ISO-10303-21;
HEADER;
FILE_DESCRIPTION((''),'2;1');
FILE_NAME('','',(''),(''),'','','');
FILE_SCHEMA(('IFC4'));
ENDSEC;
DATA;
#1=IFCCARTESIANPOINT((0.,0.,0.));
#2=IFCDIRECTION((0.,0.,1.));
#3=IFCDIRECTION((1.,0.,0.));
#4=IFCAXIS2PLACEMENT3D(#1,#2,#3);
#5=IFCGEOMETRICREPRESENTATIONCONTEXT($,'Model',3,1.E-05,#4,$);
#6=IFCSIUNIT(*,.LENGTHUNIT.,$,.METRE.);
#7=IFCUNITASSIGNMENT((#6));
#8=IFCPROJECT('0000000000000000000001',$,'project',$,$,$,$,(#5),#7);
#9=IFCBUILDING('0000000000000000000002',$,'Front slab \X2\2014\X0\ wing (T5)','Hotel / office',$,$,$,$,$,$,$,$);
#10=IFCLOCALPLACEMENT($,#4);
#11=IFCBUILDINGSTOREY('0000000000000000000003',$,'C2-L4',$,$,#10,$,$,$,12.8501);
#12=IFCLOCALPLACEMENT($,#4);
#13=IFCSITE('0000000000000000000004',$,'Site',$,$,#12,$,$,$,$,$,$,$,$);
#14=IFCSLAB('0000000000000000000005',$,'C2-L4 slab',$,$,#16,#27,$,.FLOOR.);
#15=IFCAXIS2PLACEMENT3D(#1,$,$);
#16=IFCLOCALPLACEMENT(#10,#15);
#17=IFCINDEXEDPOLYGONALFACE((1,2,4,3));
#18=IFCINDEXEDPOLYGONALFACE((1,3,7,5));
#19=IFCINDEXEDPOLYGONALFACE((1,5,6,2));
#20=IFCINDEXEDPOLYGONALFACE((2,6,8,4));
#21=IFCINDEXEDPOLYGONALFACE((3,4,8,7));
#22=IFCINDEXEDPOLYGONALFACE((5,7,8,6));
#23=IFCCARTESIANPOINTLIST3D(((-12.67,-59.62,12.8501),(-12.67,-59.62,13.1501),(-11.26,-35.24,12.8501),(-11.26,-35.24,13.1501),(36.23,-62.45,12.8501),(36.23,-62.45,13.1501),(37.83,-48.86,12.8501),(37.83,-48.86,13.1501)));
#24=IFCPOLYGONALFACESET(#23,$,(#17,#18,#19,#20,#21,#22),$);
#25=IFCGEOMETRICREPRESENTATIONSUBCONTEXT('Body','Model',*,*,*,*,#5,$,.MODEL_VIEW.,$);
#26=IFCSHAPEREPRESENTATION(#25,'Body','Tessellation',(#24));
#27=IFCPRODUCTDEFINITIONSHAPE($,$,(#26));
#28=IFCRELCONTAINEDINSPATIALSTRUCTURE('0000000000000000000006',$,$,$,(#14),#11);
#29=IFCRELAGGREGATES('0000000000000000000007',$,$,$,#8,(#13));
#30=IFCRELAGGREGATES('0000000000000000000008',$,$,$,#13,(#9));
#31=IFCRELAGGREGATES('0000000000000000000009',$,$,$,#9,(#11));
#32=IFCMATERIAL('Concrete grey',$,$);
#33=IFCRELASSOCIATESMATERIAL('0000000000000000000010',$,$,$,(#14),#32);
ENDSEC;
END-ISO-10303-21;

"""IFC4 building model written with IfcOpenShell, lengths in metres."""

from ifc_helpers import new_model, si_unit, frame, origin_with_axes, place, context, subcontext, project, spatial, polyline, outline, extrude, material, element, save


model = new_model("IFC4")

# Units and contexts
model_context = context("Model", 3, precision=1e-05, world=origin_with_axes())
body_context = subcontext(model_context, "Body", "Model", "MODEL_VIEW")
ifc_project = project(units=[si_unit("LENGTHUNIT", "METRE")], contexts=[model_context])

# Site, building, storey
site_placement = place(None, origin_with_axes())
site = spatial("IfcSite", under=ifc_project, at=site_placement, Name="Site")
building = spatial("IfcBuilding", under=site, Name="Front slab — wing (T5)", Description="Hotel / office")
storey_placement = place(None, origin_with_axes())
storey = spatial("IfcBuildingStorey", under=building, at=storey_placement, Name="C2-L4", Elevation=12.8501)

# Slab
ifc_material_1 = material(Name="Concrete grey")
slab_placement = place(storey_placement, origin_with_axes())
element("IfcSlab", 1, at=slab_placement, inside=storey, material=ifc_material_1, Name="C2-L4 slab", PredefinedType="FLOOR", context=body_context, shape_type="SweptSolid", body=[
    extrude(outline(polyline([(-11.26, -35.24), (-12.67, -59.62), (36.23, -62.45), (37.83, -48.86), (-11.26, -35.24)])), frame((0.0, 0.0, 12.8501), z_axis=(0.0, 0.0, 1.0), x_axis=(1.0, 0.0, 0.0)), (0.0, 0.0, 1.0), 0.3),
])

save(model, "model.ifc")
